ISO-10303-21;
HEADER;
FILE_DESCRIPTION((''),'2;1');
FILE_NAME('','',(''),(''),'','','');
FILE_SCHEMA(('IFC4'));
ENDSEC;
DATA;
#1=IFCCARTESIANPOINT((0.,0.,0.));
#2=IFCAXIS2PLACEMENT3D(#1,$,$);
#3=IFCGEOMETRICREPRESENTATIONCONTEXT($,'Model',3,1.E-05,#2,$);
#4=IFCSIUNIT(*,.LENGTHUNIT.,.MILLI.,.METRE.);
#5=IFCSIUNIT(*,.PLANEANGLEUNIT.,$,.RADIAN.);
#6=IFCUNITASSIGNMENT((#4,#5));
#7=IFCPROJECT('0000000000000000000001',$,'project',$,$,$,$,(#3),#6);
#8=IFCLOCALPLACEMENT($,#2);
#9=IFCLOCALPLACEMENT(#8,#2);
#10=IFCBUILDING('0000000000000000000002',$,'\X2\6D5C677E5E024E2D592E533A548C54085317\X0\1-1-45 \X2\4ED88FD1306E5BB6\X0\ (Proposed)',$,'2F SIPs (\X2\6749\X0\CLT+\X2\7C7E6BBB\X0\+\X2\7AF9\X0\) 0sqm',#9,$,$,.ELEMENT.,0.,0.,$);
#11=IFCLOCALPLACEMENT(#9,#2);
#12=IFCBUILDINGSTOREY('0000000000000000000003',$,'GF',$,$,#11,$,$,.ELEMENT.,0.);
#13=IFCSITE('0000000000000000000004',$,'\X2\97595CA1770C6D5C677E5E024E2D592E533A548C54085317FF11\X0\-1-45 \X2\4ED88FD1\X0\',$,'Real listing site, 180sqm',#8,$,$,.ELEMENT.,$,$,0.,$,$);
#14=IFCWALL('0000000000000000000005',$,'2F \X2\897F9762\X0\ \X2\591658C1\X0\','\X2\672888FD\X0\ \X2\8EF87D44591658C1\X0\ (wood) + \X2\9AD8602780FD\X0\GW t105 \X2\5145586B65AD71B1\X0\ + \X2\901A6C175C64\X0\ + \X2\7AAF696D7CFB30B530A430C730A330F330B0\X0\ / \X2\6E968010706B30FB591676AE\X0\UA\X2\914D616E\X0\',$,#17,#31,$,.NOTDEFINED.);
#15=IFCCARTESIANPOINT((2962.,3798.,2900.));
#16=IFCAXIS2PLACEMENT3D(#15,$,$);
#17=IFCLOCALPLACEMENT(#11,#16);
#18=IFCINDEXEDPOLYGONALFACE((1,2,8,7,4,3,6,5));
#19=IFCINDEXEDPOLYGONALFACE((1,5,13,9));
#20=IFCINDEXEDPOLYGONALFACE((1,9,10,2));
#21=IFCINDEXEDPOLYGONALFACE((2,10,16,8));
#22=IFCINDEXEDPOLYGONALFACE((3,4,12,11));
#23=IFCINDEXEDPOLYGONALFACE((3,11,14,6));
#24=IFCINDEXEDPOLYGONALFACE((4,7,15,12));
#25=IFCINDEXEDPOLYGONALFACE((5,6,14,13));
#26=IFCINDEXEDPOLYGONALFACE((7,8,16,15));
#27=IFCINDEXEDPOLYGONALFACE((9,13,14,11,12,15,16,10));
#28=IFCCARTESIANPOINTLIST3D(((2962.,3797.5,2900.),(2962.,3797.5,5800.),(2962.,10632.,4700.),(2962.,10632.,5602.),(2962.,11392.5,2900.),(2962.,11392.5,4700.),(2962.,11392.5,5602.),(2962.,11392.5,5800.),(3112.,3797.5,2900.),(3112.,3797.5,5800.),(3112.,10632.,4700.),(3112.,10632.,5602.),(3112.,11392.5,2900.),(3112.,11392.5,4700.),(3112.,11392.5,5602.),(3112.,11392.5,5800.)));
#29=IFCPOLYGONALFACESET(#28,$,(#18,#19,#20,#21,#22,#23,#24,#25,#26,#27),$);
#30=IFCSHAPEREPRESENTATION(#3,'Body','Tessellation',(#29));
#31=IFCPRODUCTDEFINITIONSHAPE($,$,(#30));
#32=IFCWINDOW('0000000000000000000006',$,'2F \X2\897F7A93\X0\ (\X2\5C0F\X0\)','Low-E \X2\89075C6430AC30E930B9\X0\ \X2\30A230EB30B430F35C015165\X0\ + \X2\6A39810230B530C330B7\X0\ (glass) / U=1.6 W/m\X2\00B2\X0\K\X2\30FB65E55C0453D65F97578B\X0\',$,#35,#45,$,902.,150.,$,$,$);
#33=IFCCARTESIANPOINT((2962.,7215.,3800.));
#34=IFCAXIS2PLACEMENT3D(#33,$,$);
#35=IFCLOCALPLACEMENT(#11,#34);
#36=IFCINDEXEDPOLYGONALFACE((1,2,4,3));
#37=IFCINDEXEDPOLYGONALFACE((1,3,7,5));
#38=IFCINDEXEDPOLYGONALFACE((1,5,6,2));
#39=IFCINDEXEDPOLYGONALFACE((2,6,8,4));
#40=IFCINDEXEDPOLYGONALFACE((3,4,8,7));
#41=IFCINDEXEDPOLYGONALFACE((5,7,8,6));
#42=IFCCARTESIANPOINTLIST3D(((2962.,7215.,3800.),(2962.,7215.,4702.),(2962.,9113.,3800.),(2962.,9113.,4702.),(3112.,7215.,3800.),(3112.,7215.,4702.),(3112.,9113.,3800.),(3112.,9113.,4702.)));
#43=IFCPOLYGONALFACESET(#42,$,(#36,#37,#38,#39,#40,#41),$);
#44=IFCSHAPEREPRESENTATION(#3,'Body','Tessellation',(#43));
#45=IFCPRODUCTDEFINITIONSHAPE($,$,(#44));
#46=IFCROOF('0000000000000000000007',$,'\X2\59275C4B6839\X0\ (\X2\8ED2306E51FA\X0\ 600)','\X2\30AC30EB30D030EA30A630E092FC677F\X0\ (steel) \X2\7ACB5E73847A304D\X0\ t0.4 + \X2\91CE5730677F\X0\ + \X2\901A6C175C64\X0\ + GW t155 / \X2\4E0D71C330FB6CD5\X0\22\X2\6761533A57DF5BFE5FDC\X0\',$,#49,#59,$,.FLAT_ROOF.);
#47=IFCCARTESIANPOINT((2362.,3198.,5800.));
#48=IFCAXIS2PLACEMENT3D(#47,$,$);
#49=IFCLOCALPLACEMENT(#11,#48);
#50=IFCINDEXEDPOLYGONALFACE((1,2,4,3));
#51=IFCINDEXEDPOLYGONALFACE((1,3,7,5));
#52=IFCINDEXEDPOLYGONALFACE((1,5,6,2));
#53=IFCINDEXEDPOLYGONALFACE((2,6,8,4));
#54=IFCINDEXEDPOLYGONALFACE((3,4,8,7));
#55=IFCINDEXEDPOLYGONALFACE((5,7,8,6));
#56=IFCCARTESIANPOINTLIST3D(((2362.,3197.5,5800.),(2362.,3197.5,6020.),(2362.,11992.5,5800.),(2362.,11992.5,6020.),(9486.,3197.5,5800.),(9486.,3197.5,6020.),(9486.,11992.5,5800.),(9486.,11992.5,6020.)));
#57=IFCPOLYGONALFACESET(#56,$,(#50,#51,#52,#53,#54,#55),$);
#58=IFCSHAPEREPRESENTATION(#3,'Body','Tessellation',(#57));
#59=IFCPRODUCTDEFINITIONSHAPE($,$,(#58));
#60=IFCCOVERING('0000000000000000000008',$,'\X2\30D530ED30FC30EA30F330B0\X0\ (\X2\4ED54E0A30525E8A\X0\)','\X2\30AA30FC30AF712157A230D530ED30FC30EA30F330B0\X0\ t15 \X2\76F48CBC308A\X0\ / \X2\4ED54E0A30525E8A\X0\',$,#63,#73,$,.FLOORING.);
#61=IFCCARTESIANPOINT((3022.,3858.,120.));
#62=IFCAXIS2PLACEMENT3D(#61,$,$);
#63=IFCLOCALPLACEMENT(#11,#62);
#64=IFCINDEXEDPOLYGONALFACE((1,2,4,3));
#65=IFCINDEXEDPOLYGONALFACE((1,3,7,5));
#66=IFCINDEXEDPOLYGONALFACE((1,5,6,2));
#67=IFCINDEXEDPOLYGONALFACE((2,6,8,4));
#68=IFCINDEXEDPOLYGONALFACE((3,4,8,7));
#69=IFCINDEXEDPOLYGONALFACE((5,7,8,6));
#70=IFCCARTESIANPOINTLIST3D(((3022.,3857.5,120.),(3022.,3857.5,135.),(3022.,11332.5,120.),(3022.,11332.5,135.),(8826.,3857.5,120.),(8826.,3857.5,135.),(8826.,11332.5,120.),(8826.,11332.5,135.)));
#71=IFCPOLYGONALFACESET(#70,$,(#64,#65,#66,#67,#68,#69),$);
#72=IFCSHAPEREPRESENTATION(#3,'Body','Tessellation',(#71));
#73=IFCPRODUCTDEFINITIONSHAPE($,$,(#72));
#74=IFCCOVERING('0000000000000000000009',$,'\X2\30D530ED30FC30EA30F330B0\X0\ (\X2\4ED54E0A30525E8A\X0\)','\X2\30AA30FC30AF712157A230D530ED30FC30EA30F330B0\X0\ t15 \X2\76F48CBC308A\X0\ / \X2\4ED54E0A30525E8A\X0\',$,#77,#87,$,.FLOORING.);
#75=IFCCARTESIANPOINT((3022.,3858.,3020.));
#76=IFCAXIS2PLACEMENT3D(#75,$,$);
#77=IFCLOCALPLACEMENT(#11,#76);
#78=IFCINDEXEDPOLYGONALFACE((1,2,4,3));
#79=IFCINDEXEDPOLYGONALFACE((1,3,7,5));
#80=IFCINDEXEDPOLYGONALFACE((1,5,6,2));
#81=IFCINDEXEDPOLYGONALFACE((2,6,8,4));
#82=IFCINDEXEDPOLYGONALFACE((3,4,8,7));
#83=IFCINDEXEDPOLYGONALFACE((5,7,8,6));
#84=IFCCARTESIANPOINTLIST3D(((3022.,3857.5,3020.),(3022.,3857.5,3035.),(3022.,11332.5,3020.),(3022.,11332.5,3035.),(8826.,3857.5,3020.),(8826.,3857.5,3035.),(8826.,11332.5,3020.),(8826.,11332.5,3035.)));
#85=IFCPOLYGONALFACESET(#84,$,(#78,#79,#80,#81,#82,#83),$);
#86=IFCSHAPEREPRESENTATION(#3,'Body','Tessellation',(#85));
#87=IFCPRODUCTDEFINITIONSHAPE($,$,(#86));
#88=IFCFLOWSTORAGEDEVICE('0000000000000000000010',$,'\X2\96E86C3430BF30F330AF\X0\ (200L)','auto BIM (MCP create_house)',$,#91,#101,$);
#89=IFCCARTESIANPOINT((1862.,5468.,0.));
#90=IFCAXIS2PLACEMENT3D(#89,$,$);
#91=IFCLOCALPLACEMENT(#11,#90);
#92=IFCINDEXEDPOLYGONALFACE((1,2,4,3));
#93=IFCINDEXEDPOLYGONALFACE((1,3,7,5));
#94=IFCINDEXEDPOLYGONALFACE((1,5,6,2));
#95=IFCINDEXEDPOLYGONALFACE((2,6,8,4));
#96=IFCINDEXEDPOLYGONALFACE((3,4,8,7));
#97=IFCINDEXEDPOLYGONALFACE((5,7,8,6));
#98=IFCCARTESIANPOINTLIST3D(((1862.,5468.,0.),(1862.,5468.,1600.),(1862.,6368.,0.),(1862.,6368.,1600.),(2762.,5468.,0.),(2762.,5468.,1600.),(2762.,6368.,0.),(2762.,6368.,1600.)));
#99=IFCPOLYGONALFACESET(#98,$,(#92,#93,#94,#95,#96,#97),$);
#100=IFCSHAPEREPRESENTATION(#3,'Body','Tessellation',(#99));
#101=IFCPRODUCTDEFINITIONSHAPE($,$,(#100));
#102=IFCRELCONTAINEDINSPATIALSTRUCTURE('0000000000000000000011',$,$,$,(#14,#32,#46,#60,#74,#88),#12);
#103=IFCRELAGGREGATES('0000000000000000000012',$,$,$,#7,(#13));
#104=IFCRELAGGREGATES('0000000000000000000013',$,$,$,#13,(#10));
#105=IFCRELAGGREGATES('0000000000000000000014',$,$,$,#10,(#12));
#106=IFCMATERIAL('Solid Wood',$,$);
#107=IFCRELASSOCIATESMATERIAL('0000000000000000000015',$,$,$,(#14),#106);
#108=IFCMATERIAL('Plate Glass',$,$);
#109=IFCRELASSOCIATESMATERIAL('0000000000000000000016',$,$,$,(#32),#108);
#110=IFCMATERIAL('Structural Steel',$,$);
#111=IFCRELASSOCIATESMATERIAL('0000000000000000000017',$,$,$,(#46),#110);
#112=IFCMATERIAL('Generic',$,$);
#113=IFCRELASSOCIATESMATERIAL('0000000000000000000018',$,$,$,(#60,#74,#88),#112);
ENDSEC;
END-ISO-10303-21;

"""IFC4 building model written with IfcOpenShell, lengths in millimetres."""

from ifc_helpers import new_model, si_unit, frame, frame_2d, origin, place, context, project, spatial, rectangle, extrude, material, element, fill, save


model = new_model("IFC4")

# Units and contexts
model_context = context("Model", 3, precision=1e-05, world=origin())
ifc_project = project(units=[si_unit("LENGTHUNIT", "METRE", prefix="MILLI"), si_unit("PLANEANGLEUNIT", "RADIAN")], contexts=[model_context])

# Site, building, storey
site_placement = place(None, origin())
site = spatial("IfcSite", under=ifc_project, at=site_placement, Name="静岡県浜松市中央区和合北１-1-45 付近", ObjectType="Real listing site, 180sqm", CompositionType="ELEMENT", RefElevation=0.0)
building_placement = place(site_placement, origin())
building = spatial("IfcBuilding", under=site, at=building_placement, Name="浜松市中央区和合北1-1-45 付近の家 (Proposed)", ObjectType="2F SIPs (杉CLT+籾殻+竹) 0sqm", CompositionType="ELEMENT", ElevationOfRefHeight=0.0, ElevationOfTerrain=0.0)
storey_placement = place(building_placement, origin())
storey = spatial("IfcBuildingStorey", under=building, at=storey_placement, Name="GF", CompositionType="ELEMENT", Elevation=0.0)

# Shared definitions
ifc_material_1 = material(Name="Solid Wood")

# Shared definitions
ifc_material_2 = material(Name="Plate Glass")

# Wall, opening, window
wall_1_placement = place(storey_placement, frame((2962.0, 3798.0, 2900.0)))
wall_1 = element("IfcWall", 1, at=wall_1_placement, inside=storey, material=ifc_material_1, Name="2F 西面 外壁", Description="木製 軸組外壁 (wood) + 高性能GW t105 充填断熱 + 通気層 + 窯業系サイディング / 準耐火・外皮UA配慮", PredefinedType="NOTDEFINED", context=model_context, shape_type="SweptSolid", body=[
    extrude(rectangle(XDim=150.0, YDim=7595.0, at=frame_2d((75.0, 3797.0))), frame((2962.0, 3798.0, 2900.0)), (0.0, 0.0, 1.0), 2900.0),
])
opening_1_placement = place(storey_placement, frame((2962.0, 7215.0, 3800.0)))
opening_1 = element("IfcOpeningElement", 2, at=opening_1_placement, cuts=wall_1, PredefinedType="NOTDEFINED", context=model_context, shape_type="SweptSolid", body=[
    extrude(rectangle(XDim=150.0, YDim=1898.0, at=frame_2d((75.0, 949.0))), frame((2962.0, 7215.0, 3800.0)), (0.0, 0.0, 1.0), 902.0),
])
window_1_placement = place(storey_placement, frame((2962.0, 7215.0, 3800.0)))
window_1 = element("IfcWindow", 3, at=window_1_placement, inside=storey, material=ifc_material_2, Name="2F 西窓 (小)", Description="Low-E 複層ガラス アルゴン封入 + 樹脂サッシ (glass) / U=1.6 W/m²K・日射取得型", OverallHeight=902.0, OverallWidth=150.0, context=model_context, shape_type="SweptSolid", body=[
    extrude(rectangle(XDim=150.0, YDim=1898.0, at=frame_2d((75.0, 949.0))), frame((2962.0, 7215.0, 3800.0)), (0.0, 0.0, 1.0), 902.0),
])
fill(opening_1, window_1)

# Roof
ifc_material_3 = material(Name="Structural Steel")
roof_placement = place(storey_placement, frame((2362.0, 3198.0, 5800.0)))
element("IfcRoof", 4, at=roof_placement, inside=storey, material=ifc_material_3, Name="大屋根 (軒の出 600)", Description="ガルバリウム鋼板 (steel) 立平葺き t0.4 + 野地板 + 通気層 + GW t155 / 不燃・法22条区域対応", PredefinedType="FLAT_ROOF", context=model_context, shape_type="SweptSolid", body=[
    extrude(rectangle(XDim=7124.0, YDim=8795.0, at=frame_2d((3562.0, 4397.0))), frame((2362.0, 3198.0, 5800.0)), (0.0, 0.0, 1.0), 220.0),
])

# Coverings
ifc_material_4 = material(Name="Generic")
covering_1_placement = place(storey_placement, frame((3022.0, 3858.0, 120.0)))
element("IfcCovering", 5, at=covering_1_placement, inside=storey, material=ifc_material_4, Name="フローリング (仕上げ床)", Description="オーク無垢フローリング t15 直貼り / 仕上げ床", PredefinedType="FLOORING", context=model_context, shape_type="SweptSolid", body=[
    extrude(rectangle(XDim=5804.0, YDim=7475.0, at=frame_2d((2902.0, 3737.0))), frame((3022.0, 3858.0, 120.0)), (0.0, 0.0, 1.0), 15.0),
])
covering_2_placement = place(storey_placement, frame((3022.0, 3858.0, 3020.0)))
element("IfcCovering", 6, at=covering_2_placement, inside=storey, material=ifc_material_4, Name="フローリング (仕上げ床)", Description="オーク無垢フローリング t15 直貼り / 仕上げ床", PredefinedType="FLOORING", context=model_context, shape_type="SweptSolid", body=[
    extrude(rectangle(XDim=5804.0, YDim=7475.0, at=frame_2d((2902.0, 3737.0))), frame((3022.0, 3858.0, 3020.0)), (0.0, 0.0, 1.0), 15.0),
])

# Flow storage device
flow_storage_device_placement = place(storey_placement, frame((1862.0, 5468.0, 0.0)))
element("IfcFlowStorageDevice", 7, at=flow_storage_device_placement, inside=storey, material=ifc_material_4, Name="雨水タンク (200L)", Description="auto BIM (MCP create_house)", context=model_context, shape_type="SweptSolid", body=[
    extrude(rectangle(XDim=900.0, YDim=900.0, at=frame_2d((450.0, 450.0))), frame((1862.0, 5468.0, 0.0)), (0.0, 0.0, 1.0), 1600.0),
])

save(model, "model.ifc")
